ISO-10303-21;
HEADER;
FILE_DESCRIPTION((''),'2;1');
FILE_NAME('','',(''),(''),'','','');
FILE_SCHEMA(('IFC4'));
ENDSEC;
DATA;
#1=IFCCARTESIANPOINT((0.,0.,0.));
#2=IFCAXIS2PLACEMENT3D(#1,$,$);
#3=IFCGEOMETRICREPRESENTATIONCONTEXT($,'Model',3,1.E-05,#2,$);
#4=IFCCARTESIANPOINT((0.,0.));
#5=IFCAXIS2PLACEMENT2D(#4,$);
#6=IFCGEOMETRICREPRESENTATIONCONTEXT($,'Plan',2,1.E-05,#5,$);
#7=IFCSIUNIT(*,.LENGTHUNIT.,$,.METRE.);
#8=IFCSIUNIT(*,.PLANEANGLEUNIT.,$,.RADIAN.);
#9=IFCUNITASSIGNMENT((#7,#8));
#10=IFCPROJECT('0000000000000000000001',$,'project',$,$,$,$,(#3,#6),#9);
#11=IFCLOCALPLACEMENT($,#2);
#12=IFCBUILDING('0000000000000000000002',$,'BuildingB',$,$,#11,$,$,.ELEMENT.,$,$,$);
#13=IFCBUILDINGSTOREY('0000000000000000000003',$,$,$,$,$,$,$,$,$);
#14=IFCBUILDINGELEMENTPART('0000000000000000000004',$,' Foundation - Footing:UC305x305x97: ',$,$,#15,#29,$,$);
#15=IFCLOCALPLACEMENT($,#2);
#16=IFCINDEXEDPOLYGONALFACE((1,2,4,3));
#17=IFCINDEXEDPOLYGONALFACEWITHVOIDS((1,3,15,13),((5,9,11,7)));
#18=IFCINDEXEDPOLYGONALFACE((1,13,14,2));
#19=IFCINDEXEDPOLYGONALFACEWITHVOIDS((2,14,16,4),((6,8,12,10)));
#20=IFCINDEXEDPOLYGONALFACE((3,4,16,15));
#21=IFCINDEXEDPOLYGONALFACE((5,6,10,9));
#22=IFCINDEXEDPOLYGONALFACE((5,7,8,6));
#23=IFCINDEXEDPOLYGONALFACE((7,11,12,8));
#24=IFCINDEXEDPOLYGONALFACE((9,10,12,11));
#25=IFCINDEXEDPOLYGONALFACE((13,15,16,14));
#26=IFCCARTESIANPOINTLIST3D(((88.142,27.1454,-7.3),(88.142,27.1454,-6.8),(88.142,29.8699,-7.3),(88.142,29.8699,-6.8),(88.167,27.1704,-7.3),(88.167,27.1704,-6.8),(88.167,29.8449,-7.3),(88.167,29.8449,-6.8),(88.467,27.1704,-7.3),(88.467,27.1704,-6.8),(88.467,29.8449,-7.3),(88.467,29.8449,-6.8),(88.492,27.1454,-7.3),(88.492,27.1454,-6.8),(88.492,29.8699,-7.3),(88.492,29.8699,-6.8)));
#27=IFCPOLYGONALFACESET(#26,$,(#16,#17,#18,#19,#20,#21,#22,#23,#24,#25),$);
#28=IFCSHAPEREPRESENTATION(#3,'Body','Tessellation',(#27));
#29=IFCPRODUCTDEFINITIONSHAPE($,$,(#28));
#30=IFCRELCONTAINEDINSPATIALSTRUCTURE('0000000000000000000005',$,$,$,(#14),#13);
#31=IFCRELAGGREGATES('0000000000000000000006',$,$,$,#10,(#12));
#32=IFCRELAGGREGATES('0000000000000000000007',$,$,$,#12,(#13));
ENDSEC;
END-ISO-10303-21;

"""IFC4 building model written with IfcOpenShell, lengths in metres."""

from ifc_helpers import new_model, si_unit, origin, origin_2d, place, context, project, spatial, polyline, outline, extrude, element, save


model = new_model("IFC4")

# Units and contexts
model_context = context("Model", 3, precision=1e-05, world=origin())
plan_context = context("Plan", 2, precision=1e-05, world=origin_2d())
ifc_project = project(units=[si_unit("LENGTHUNIT", "METRE"), si_unit("PLANEANGLEUNIT", "RADIAN")], contexts=[model_context, plan_context])

# Building, storey
building_placement = place(None, origin())
building = spatial("IfcBuilding", under=ifc_project, at=building_placement, Name="BuildingB", CompositionType="ELEMENT")
storey = spatial("IfcBuildingStorey", under=building)

# Building element part, opening
building_element_part_1 = element("IfcBuildingElementPart", 1, inside=storey, Name=" Foundation - Footing:UC305x305x97: ", context=model_context, shape_type="SweptSolid", body=[
    extrude(outline(polyline([(88.492, 27.1454, -7.3), (88.142, 27.1454, -7.3), (88.142, 29.8699, -7.3), (88.492, 29.8699, -7.3), (88.492, 27.1454, -7.3)])), None, (0.0, 0.0, 1.0), 0.5),
])
element("IfcOpeningElement", 2, inside=storey, cuts=building_element_part_1, context=model_context, shape_type="SweptSolid", body=[
    extrude(outline(polyline([(88.467, 27.1704, -7.3), (88.167, 27.1704, -7.3), (88.167, 29.8449, -7.3), (88.467, 29.8449, -7.3), (88.467, 27.1704, -7.3)])), None, (0.0, 0.0, 1.0), 0.5),
])

save(model, "model.ifc")
